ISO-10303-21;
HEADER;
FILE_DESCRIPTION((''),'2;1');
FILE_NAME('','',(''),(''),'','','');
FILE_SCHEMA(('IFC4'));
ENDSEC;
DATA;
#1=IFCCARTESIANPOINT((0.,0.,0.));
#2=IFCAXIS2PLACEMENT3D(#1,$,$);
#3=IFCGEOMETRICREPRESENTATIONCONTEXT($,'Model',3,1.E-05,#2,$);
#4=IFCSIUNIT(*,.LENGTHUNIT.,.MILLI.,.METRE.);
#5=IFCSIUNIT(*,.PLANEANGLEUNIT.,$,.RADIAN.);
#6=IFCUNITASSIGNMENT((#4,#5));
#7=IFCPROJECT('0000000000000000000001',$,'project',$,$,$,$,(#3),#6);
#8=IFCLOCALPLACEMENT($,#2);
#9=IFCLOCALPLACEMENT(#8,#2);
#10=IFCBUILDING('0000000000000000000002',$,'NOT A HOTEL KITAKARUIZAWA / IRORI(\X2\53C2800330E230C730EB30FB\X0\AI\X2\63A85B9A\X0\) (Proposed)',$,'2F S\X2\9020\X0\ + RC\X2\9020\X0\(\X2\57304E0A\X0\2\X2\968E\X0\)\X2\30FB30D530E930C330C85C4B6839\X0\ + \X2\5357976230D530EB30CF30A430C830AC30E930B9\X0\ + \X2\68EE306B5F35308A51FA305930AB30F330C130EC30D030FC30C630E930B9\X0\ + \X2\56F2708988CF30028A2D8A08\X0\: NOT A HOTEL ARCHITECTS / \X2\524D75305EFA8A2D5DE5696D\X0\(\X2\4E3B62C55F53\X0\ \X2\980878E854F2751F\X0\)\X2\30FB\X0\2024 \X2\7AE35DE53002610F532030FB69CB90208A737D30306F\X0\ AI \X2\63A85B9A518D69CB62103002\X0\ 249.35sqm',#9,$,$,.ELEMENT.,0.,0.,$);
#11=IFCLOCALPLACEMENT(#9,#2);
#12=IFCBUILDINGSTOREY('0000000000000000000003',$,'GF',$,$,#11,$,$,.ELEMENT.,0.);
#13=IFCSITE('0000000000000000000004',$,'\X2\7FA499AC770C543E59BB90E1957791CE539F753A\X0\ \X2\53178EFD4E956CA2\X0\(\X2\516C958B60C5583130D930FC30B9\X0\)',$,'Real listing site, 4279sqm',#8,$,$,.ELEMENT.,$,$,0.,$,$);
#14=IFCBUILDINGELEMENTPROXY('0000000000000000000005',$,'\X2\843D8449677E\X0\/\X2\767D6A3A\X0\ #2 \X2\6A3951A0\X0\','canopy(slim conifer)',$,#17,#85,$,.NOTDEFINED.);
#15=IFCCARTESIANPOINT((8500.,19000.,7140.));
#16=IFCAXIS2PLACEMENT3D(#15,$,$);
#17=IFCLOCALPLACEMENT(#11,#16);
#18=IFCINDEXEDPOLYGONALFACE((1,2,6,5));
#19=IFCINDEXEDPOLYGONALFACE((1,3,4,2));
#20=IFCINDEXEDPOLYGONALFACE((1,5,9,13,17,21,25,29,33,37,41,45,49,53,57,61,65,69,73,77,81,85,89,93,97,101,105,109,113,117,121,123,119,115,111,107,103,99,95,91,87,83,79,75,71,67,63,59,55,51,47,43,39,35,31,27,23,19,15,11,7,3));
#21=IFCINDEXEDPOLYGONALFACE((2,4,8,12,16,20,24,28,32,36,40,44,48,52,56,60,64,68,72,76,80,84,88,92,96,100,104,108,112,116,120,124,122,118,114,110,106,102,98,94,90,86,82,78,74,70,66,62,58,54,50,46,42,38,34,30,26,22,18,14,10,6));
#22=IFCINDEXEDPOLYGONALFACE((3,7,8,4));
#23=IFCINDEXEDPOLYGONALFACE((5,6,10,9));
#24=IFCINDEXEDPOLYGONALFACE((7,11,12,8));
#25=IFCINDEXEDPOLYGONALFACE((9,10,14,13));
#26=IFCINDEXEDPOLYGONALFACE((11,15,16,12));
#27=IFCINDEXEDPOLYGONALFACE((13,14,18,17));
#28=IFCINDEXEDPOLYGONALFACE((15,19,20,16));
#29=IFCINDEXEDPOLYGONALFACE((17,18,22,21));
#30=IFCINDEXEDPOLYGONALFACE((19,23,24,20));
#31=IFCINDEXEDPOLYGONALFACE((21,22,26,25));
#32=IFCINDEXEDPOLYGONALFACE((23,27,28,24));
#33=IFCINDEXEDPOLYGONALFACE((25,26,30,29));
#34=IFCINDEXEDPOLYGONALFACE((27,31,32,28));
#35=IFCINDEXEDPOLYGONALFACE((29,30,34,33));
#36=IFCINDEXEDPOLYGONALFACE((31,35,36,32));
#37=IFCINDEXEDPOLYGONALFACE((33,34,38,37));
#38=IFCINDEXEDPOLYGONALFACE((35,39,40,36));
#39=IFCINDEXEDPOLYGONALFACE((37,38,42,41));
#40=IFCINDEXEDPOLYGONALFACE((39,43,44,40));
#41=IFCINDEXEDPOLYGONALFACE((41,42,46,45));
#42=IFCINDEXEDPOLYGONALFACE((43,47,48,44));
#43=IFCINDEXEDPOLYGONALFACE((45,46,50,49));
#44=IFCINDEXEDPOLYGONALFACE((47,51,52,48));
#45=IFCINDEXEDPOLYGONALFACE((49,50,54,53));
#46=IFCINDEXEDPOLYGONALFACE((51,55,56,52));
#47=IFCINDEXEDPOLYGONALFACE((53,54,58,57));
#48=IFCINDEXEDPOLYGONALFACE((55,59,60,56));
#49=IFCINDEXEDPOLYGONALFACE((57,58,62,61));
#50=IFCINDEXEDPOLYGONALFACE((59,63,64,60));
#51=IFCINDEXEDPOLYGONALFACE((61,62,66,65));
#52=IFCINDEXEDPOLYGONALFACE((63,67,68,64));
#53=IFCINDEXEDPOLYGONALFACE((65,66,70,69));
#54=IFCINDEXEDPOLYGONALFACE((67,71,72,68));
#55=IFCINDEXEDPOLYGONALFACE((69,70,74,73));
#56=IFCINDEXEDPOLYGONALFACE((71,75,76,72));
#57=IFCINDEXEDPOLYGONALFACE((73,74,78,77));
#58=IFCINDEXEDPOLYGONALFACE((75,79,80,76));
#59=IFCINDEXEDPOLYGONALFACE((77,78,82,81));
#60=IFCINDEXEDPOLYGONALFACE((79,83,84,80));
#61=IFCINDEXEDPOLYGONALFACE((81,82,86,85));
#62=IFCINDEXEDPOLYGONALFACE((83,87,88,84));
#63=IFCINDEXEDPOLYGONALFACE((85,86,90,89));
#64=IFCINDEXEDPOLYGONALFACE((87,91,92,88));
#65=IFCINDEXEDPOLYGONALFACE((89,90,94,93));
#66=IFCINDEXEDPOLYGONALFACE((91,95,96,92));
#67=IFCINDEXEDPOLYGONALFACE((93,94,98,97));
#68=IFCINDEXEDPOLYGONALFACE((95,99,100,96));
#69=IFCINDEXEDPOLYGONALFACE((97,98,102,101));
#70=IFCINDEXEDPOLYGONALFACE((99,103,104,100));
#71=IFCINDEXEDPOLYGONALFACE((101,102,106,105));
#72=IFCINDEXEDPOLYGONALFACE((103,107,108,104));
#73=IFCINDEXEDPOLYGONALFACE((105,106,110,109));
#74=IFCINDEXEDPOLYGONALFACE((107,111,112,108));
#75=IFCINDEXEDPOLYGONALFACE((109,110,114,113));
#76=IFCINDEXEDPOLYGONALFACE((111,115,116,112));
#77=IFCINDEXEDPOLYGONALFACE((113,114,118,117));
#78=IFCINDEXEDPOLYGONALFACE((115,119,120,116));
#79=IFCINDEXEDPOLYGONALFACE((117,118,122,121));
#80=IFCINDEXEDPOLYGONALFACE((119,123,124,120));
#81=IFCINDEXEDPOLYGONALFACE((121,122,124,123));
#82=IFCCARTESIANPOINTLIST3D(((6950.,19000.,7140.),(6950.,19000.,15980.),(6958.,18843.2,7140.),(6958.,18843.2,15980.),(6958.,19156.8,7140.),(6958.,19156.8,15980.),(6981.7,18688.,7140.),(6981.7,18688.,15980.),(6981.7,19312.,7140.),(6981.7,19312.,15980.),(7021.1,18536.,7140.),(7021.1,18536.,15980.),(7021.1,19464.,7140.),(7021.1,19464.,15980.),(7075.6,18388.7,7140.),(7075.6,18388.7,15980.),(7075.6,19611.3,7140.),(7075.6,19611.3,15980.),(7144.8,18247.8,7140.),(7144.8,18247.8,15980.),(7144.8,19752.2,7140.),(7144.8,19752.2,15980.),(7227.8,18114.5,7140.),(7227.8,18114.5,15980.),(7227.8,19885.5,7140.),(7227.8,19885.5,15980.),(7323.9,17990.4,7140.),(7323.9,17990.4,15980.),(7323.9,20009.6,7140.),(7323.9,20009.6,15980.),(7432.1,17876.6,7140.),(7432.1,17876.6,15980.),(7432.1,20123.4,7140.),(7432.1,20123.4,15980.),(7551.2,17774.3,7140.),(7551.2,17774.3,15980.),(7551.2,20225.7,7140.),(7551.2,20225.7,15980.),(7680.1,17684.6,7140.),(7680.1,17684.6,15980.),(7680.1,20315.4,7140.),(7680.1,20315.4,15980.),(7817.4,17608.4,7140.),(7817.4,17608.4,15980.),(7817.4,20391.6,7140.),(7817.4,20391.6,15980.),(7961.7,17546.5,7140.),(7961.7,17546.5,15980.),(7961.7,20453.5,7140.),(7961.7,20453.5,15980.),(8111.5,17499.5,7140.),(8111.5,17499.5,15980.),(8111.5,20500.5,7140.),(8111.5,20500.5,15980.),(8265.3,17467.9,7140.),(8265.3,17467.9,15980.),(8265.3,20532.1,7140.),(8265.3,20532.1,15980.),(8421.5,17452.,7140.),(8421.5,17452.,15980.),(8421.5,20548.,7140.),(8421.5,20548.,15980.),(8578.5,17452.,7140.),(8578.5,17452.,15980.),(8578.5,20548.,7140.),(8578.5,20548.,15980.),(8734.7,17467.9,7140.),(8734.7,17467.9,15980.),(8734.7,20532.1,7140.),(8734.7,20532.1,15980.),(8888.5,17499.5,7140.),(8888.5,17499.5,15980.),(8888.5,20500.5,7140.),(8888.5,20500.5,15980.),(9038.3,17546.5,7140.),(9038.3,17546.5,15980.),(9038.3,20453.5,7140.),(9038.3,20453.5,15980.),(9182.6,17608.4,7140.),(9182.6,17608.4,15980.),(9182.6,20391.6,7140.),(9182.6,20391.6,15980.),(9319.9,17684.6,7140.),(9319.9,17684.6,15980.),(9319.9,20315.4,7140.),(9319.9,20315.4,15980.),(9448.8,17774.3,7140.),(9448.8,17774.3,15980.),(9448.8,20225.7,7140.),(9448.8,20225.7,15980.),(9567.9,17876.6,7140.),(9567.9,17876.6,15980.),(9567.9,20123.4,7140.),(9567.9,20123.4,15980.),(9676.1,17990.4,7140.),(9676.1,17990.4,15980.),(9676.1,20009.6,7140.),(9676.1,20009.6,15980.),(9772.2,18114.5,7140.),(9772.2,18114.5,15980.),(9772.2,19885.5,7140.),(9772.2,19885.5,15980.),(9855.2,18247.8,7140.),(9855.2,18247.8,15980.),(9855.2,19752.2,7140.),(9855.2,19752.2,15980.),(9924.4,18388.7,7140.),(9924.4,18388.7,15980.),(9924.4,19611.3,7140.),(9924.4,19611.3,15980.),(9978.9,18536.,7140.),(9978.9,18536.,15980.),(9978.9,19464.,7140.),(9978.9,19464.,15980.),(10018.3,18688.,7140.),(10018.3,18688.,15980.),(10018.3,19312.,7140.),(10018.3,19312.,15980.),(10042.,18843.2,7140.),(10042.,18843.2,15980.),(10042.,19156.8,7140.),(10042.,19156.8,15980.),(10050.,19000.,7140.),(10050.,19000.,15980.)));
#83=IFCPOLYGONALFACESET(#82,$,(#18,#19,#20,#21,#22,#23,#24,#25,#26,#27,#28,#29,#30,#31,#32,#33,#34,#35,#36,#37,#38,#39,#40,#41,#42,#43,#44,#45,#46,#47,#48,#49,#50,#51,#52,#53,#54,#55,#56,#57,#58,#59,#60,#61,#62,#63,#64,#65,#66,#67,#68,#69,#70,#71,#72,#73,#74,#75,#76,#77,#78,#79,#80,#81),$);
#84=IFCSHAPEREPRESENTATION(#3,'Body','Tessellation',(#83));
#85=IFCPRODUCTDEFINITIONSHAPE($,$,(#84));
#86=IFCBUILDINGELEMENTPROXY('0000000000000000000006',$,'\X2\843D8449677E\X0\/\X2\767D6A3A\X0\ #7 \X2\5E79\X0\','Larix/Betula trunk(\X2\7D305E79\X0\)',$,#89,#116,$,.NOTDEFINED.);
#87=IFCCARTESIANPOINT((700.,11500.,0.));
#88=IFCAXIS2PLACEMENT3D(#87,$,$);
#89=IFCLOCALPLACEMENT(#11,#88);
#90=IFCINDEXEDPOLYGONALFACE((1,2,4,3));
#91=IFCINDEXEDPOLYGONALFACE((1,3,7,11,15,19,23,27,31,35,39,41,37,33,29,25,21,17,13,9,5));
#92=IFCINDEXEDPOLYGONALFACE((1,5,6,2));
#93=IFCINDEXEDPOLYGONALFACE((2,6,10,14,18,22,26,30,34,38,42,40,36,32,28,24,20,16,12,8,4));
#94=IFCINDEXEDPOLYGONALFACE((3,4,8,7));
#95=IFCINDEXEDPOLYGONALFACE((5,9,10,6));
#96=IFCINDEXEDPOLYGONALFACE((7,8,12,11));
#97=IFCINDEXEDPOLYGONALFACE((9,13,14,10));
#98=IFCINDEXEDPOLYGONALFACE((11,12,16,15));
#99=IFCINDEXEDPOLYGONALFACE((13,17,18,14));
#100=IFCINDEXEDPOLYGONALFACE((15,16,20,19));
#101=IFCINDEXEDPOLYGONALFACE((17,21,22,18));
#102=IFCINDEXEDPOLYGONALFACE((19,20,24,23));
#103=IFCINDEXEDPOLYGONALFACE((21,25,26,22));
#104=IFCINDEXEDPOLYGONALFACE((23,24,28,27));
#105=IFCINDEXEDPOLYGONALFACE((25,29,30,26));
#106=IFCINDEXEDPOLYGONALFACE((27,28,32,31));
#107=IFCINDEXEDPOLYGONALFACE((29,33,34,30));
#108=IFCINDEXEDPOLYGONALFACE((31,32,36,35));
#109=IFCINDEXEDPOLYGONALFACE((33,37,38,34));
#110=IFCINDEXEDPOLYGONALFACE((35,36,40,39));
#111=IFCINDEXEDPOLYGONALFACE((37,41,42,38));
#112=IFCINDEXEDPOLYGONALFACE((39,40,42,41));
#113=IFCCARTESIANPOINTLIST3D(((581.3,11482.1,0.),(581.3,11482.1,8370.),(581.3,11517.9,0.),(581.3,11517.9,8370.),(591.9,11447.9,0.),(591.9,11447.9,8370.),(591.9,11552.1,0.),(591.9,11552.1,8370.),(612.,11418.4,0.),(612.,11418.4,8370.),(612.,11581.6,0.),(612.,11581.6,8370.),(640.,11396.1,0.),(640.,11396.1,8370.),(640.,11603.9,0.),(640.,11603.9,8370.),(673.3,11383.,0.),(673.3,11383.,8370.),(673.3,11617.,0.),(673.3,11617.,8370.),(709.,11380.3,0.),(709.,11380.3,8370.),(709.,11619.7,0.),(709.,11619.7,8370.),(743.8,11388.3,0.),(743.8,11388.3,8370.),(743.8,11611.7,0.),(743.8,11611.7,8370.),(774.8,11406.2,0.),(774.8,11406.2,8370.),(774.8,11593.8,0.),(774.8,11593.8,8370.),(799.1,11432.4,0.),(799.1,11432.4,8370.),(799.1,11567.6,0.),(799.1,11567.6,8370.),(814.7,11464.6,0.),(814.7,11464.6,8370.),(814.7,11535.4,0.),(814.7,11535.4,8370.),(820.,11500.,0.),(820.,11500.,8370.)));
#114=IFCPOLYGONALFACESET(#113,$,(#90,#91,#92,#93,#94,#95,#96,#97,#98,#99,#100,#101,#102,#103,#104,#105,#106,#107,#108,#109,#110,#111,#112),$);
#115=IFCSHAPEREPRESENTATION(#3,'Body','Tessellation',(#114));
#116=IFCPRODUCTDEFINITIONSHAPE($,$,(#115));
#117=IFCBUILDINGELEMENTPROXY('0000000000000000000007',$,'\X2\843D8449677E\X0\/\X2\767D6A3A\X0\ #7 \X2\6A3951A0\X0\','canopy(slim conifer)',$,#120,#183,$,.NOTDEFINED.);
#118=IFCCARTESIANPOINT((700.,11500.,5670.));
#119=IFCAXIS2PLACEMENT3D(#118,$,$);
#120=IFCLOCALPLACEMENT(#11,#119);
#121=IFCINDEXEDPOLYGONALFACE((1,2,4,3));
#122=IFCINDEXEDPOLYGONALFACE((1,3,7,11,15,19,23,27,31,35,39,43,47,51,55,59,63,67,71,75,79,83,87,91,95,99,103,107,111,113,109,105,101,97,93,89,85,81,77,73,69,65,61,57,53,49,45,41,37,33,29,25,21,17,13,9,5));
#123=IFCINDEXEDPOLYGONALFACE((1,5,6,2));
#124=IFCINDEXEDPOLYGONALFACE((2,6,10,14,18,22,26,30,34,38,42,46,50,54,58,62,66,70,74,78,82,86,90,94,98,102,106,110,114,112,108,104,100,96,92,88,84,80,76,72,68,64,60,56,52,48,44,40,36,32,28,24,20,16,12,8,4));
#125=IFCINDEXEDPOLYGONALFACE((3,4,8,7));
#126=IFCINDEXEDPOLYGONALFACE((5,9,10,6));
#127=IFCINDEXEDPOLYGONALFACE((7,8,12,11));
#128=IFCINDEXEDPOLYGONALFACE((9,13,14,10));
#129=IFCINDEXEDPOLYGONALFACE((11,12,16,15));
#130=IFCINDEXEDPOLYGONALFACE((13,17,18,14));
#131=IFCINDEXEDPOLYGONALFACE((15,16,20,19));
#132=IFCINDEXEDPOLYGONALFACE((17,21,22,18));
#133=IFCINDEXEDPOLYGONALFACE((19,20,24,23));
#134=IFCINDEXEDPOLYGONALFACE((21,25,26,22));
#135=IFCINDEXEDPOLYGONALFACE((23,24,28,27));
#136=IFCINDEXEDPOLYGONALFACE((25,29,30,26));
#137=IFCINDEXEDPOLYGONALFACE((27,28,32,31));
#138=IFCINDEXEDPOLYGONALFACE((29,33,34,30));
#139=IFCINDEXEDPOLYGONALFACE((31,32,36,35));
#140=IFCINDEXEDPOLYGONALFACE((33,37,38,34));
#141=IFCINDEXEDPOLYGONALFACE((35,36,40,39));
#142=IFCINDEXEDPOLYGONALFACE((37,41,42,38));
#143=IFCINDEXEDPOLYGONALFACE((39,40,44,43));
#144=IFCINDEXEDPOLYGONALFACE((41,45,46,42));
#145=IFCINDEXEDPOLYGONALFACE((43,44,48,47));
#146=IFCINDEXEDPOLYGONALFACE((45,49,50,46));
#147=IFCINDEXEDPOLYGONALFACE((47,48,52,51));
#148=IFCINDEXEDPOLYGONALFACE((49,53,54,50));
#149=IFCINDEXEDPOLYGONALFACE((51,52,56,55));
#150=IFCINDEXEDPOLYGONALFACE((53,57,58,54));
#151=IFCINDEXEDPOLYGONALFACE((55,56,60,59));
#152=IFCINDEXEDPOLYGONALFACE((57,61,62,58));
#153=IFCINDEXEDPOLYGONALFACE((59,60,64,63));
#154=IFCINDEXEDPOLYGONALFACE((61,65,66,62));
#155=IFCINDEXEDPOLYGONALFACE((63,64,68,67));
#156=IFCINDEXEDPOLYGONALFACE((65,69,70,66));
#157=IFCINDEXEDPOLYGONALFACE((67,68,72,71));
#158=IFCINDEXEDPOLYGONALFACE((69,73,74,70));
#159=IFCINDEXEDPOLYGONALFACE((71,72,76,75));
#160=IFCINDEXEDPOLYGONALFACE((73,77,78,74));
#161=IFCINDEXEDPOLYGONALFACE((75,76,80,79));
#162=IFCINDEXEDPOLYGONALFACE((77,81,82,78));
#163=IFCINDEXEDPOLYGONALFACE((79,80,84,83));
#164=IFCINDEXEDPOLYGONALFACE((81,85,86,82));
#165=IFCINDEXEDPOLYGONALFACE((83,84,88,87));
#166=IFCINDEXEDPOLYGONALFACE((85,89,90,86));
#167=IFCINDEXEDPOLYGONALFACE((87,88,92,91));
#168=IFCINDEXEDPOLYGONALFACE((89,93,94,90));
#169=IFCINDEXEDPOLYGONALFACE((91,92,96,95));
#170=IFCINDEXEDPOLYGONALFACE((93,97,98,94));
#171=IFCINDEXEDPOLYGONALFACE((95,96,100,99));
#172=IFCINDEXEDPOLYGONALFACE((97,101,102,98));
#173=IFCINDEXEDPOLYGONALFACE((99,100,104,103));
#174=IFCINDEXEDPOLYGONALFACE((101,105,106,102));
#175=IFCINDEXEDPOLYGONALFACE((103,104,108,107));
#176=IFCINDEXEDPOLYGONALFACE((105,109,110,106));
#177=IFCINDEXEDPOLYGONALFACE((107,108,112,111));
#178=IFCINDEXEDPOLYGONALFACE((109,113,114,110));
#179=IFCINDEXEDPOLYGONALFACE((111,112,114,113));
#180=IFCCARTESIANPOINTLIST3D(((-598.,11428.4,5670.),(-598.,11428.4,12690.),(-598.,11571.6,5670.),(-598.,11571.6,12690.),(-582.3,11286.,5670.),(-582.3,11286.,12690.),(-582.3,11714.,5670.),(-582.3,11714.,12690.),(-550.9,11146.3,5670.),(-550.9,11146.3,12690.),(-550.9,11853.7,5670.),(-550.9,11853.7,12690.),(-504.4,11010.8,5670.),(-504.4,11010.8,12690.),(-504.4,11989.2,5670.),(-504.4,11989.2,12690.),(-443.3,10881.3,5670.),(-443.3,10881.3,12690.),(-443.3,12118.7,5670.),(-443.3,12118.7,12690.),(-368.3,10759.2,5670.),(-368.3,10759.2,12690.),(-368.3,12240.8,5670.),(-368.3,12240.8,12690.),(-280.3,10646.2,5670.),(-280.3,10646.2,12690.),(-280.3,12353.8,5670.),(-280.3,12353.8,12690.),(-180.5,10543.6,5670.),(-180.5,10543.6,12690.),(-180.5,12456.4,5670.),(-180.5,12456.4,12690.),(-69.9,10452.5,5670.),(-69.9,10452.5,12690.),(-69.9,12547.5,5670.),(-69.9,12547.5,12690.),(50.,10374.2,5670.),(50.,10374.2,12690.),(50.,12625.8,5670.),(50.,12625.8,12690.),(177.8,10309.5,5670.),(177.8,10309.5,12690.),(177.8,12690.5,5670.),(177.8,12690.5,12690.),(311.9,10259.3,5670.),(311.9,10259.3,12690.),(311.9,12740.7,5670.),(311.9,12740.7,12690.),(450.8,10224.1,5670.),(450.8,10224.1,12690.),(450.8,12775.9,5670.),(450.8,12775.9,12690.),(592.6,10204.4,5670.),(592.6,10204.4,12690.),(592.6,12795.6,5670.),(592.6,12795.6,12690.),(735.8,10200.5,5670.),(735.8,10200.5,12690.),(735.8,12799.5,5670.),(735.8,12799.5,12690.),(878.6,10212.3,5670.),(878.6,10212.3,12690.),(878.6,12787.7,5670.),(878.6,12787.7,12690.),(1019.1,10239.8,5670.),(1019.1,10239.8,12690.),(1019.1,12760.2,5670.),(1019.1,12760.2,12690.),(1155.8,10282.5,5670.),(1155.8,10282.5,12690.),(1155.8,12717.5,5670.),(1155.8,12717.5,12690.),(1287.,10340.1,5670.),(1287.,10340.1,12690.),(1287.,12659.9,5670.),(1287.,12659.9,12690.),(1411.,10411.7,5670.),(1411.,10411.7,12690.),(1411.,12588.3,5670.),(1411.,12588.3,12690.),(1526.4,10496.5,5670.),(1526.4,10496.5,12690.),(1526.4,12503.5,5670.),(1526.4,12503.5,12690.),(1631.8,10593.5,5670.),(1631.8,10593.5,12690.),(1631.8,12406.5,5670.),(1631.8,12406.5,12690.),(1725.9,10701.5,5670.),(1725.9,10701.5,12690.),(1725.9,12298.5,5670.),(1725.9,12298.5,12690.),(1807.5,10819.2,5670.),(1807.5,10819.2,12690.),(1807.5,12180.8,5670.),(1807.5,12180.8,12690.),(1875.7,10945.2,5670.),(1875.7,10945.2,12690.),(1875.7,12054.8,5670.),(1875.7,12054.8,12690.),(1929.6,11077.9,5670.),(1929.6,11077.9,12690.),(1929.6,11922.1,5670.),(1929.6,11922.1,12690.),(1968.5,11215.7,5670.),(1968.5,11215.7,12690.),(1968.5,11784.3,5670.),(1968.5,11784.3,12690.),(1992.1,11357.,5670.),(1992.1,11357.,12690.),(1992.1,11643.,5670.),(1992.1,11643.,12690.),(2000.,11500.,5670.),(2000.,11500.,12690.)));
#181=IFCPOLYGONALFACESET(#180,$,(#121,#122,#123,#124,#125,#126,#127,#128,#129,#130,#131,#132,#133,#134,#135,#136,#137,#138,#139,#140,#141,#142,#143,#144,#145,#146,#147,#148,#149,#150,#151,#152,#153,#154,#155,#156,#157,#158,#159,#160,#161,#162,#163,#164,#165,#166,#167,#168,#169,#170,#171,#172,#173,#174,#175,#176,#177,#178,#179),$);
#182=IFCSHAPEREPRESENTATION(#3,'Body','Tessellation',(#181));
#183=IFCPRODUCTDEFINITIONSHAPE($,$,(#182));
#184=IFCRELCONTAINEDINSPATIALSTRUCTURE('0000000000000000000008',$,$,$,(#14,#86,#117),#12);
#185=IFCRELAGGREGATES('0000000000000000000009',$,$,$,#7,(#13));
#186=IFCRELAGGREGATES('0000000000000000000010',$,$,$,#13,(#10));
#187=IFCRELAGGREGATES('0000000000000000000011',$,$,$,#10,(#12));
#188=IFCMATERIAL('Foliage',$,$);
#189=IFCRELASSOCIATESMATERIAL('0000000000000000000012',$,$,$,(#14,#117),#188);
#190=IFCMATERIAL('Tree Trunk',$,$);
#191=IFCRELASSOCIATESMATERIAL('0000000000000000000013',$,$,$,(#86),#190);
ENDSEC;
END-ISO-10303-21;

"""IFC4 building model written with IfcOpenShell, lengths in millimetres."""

from ifc_helpers import new_model, si_unit, frame, origin, origin_2d, place, context, project, spatial, circle, extrude, material, element, save


model = new_model("IFC4")

# Units and contexts
model_context = context("Model", 3, precision=1e-05, world=origin())
ifc_project = project(units=[si_unit("LENGTHUNIT", "METRE", prefix="MILLI"), si_unit("PLANEANGLEUNIT", "RADIAN")], contexts=[model_context])

# Site, building, storey
site_placement = place(None, origin())
site = spatial("IfcSite", under=ifc_project, at=site_placement, Name="群馬県吾妻郡長野原町 北軽井沢(公開情報ベース)", ObjectType="Real listing site, 4279sqm", CompositionType="ELEMENT", RefElevation=0.0)
building_placement = place(site_placement, origin())
building = spatial("IfcBuilding", under=site, at=building_placement, Name="NOT A HOTEL KITAKARUIZAWA / IRORI(参考モデル・AI推定) (Proposed)", ObjectType="2F S造 + RC造(地上2階)・フラット屋根 + 南面フルハイトガラス + 森に張り出すカンチレバーテラス + 囲炉裏。設計: NOT A HOTEL ARCHITECTS / 前田建設工業(主担当 須磨哲生)・2024 竣工。意匠・構造詳細は AI 推定再構成。 249.35sqm", CompositionType="ELEMENT", ElevationOfRefHeight=0.0, ElevationOfTerrain=0.0)
storey_placement = place(building_placement, origin())
storey = spatial("IfcBuildingStorey", under=building, at=storey_placement, Name="GF", CompositionType="ELEMENT", Elevation=0.0)

# Shared definitions
ifc_material_1 = material(Name="Foliage")

# Building element proxies
ifc_material_2 = material(Name="Tree Trunk")
proxy_1_placement = place(storey_placement, frame((8500.0, 19000.0, 7140.0)))
element("IfcBuildingElementProxy", 1, at=proxy_1_placement, inside=storey, material=ifc_material_1, Name="落葉松/白樺 #2 樹冠", Description="canopy(slim conifer)", PredefinedType="NOTDEFINED", context=model_context, shape_type="SweptSolid", body=[
    extrude(circle(Radius=1550.0, at=origin_2d()), frame((8500.0, 19000.0, 7140.0)), (0.0, 0.0, 1.0), 8840.0),
])
proxy_2_placement = place(storey_placement, frame((700.0, 11500.0, 0.0)))
element("IfcBuildingElementProxy", 2, at=proxy_2_placement, inside=storey, material=ifc_material_2, Name="落葉松/白樺 #7 幹", Description="Larix/Betula trunk(細幹)", PredefinedType="NOTDEFINED", context=model_context, shape_type="SweptSolid", body=[
    extrude(circle(Radius=120.0, at=origin_2d()), frame((700.0, 11500.0, 0.0)), (0.0, 0.0, 1.0), 8370.0),
])
proxy_3_placement = place(storey_placement, frame((700.0, 11500.0, 5670.0)))
element("IfcBuildingElementProxy", 3, at=proxy_3_placement, inside=storey, material=ifc_material_1, Name="落葉松/白樺 #7 樹冠", Description="canopy(slim conifer)", PredefinedType="NOTDEFINED", context=model_context, shape_type="SweptSolid", body=[
    extrude(circle(Radius=1300.0, at=origin_2d()), frame((700.0, 11500.0, 5670.0)), (0.0, 0.0, 1.0), 7020.0),
])

save(model, "model.ifc")
